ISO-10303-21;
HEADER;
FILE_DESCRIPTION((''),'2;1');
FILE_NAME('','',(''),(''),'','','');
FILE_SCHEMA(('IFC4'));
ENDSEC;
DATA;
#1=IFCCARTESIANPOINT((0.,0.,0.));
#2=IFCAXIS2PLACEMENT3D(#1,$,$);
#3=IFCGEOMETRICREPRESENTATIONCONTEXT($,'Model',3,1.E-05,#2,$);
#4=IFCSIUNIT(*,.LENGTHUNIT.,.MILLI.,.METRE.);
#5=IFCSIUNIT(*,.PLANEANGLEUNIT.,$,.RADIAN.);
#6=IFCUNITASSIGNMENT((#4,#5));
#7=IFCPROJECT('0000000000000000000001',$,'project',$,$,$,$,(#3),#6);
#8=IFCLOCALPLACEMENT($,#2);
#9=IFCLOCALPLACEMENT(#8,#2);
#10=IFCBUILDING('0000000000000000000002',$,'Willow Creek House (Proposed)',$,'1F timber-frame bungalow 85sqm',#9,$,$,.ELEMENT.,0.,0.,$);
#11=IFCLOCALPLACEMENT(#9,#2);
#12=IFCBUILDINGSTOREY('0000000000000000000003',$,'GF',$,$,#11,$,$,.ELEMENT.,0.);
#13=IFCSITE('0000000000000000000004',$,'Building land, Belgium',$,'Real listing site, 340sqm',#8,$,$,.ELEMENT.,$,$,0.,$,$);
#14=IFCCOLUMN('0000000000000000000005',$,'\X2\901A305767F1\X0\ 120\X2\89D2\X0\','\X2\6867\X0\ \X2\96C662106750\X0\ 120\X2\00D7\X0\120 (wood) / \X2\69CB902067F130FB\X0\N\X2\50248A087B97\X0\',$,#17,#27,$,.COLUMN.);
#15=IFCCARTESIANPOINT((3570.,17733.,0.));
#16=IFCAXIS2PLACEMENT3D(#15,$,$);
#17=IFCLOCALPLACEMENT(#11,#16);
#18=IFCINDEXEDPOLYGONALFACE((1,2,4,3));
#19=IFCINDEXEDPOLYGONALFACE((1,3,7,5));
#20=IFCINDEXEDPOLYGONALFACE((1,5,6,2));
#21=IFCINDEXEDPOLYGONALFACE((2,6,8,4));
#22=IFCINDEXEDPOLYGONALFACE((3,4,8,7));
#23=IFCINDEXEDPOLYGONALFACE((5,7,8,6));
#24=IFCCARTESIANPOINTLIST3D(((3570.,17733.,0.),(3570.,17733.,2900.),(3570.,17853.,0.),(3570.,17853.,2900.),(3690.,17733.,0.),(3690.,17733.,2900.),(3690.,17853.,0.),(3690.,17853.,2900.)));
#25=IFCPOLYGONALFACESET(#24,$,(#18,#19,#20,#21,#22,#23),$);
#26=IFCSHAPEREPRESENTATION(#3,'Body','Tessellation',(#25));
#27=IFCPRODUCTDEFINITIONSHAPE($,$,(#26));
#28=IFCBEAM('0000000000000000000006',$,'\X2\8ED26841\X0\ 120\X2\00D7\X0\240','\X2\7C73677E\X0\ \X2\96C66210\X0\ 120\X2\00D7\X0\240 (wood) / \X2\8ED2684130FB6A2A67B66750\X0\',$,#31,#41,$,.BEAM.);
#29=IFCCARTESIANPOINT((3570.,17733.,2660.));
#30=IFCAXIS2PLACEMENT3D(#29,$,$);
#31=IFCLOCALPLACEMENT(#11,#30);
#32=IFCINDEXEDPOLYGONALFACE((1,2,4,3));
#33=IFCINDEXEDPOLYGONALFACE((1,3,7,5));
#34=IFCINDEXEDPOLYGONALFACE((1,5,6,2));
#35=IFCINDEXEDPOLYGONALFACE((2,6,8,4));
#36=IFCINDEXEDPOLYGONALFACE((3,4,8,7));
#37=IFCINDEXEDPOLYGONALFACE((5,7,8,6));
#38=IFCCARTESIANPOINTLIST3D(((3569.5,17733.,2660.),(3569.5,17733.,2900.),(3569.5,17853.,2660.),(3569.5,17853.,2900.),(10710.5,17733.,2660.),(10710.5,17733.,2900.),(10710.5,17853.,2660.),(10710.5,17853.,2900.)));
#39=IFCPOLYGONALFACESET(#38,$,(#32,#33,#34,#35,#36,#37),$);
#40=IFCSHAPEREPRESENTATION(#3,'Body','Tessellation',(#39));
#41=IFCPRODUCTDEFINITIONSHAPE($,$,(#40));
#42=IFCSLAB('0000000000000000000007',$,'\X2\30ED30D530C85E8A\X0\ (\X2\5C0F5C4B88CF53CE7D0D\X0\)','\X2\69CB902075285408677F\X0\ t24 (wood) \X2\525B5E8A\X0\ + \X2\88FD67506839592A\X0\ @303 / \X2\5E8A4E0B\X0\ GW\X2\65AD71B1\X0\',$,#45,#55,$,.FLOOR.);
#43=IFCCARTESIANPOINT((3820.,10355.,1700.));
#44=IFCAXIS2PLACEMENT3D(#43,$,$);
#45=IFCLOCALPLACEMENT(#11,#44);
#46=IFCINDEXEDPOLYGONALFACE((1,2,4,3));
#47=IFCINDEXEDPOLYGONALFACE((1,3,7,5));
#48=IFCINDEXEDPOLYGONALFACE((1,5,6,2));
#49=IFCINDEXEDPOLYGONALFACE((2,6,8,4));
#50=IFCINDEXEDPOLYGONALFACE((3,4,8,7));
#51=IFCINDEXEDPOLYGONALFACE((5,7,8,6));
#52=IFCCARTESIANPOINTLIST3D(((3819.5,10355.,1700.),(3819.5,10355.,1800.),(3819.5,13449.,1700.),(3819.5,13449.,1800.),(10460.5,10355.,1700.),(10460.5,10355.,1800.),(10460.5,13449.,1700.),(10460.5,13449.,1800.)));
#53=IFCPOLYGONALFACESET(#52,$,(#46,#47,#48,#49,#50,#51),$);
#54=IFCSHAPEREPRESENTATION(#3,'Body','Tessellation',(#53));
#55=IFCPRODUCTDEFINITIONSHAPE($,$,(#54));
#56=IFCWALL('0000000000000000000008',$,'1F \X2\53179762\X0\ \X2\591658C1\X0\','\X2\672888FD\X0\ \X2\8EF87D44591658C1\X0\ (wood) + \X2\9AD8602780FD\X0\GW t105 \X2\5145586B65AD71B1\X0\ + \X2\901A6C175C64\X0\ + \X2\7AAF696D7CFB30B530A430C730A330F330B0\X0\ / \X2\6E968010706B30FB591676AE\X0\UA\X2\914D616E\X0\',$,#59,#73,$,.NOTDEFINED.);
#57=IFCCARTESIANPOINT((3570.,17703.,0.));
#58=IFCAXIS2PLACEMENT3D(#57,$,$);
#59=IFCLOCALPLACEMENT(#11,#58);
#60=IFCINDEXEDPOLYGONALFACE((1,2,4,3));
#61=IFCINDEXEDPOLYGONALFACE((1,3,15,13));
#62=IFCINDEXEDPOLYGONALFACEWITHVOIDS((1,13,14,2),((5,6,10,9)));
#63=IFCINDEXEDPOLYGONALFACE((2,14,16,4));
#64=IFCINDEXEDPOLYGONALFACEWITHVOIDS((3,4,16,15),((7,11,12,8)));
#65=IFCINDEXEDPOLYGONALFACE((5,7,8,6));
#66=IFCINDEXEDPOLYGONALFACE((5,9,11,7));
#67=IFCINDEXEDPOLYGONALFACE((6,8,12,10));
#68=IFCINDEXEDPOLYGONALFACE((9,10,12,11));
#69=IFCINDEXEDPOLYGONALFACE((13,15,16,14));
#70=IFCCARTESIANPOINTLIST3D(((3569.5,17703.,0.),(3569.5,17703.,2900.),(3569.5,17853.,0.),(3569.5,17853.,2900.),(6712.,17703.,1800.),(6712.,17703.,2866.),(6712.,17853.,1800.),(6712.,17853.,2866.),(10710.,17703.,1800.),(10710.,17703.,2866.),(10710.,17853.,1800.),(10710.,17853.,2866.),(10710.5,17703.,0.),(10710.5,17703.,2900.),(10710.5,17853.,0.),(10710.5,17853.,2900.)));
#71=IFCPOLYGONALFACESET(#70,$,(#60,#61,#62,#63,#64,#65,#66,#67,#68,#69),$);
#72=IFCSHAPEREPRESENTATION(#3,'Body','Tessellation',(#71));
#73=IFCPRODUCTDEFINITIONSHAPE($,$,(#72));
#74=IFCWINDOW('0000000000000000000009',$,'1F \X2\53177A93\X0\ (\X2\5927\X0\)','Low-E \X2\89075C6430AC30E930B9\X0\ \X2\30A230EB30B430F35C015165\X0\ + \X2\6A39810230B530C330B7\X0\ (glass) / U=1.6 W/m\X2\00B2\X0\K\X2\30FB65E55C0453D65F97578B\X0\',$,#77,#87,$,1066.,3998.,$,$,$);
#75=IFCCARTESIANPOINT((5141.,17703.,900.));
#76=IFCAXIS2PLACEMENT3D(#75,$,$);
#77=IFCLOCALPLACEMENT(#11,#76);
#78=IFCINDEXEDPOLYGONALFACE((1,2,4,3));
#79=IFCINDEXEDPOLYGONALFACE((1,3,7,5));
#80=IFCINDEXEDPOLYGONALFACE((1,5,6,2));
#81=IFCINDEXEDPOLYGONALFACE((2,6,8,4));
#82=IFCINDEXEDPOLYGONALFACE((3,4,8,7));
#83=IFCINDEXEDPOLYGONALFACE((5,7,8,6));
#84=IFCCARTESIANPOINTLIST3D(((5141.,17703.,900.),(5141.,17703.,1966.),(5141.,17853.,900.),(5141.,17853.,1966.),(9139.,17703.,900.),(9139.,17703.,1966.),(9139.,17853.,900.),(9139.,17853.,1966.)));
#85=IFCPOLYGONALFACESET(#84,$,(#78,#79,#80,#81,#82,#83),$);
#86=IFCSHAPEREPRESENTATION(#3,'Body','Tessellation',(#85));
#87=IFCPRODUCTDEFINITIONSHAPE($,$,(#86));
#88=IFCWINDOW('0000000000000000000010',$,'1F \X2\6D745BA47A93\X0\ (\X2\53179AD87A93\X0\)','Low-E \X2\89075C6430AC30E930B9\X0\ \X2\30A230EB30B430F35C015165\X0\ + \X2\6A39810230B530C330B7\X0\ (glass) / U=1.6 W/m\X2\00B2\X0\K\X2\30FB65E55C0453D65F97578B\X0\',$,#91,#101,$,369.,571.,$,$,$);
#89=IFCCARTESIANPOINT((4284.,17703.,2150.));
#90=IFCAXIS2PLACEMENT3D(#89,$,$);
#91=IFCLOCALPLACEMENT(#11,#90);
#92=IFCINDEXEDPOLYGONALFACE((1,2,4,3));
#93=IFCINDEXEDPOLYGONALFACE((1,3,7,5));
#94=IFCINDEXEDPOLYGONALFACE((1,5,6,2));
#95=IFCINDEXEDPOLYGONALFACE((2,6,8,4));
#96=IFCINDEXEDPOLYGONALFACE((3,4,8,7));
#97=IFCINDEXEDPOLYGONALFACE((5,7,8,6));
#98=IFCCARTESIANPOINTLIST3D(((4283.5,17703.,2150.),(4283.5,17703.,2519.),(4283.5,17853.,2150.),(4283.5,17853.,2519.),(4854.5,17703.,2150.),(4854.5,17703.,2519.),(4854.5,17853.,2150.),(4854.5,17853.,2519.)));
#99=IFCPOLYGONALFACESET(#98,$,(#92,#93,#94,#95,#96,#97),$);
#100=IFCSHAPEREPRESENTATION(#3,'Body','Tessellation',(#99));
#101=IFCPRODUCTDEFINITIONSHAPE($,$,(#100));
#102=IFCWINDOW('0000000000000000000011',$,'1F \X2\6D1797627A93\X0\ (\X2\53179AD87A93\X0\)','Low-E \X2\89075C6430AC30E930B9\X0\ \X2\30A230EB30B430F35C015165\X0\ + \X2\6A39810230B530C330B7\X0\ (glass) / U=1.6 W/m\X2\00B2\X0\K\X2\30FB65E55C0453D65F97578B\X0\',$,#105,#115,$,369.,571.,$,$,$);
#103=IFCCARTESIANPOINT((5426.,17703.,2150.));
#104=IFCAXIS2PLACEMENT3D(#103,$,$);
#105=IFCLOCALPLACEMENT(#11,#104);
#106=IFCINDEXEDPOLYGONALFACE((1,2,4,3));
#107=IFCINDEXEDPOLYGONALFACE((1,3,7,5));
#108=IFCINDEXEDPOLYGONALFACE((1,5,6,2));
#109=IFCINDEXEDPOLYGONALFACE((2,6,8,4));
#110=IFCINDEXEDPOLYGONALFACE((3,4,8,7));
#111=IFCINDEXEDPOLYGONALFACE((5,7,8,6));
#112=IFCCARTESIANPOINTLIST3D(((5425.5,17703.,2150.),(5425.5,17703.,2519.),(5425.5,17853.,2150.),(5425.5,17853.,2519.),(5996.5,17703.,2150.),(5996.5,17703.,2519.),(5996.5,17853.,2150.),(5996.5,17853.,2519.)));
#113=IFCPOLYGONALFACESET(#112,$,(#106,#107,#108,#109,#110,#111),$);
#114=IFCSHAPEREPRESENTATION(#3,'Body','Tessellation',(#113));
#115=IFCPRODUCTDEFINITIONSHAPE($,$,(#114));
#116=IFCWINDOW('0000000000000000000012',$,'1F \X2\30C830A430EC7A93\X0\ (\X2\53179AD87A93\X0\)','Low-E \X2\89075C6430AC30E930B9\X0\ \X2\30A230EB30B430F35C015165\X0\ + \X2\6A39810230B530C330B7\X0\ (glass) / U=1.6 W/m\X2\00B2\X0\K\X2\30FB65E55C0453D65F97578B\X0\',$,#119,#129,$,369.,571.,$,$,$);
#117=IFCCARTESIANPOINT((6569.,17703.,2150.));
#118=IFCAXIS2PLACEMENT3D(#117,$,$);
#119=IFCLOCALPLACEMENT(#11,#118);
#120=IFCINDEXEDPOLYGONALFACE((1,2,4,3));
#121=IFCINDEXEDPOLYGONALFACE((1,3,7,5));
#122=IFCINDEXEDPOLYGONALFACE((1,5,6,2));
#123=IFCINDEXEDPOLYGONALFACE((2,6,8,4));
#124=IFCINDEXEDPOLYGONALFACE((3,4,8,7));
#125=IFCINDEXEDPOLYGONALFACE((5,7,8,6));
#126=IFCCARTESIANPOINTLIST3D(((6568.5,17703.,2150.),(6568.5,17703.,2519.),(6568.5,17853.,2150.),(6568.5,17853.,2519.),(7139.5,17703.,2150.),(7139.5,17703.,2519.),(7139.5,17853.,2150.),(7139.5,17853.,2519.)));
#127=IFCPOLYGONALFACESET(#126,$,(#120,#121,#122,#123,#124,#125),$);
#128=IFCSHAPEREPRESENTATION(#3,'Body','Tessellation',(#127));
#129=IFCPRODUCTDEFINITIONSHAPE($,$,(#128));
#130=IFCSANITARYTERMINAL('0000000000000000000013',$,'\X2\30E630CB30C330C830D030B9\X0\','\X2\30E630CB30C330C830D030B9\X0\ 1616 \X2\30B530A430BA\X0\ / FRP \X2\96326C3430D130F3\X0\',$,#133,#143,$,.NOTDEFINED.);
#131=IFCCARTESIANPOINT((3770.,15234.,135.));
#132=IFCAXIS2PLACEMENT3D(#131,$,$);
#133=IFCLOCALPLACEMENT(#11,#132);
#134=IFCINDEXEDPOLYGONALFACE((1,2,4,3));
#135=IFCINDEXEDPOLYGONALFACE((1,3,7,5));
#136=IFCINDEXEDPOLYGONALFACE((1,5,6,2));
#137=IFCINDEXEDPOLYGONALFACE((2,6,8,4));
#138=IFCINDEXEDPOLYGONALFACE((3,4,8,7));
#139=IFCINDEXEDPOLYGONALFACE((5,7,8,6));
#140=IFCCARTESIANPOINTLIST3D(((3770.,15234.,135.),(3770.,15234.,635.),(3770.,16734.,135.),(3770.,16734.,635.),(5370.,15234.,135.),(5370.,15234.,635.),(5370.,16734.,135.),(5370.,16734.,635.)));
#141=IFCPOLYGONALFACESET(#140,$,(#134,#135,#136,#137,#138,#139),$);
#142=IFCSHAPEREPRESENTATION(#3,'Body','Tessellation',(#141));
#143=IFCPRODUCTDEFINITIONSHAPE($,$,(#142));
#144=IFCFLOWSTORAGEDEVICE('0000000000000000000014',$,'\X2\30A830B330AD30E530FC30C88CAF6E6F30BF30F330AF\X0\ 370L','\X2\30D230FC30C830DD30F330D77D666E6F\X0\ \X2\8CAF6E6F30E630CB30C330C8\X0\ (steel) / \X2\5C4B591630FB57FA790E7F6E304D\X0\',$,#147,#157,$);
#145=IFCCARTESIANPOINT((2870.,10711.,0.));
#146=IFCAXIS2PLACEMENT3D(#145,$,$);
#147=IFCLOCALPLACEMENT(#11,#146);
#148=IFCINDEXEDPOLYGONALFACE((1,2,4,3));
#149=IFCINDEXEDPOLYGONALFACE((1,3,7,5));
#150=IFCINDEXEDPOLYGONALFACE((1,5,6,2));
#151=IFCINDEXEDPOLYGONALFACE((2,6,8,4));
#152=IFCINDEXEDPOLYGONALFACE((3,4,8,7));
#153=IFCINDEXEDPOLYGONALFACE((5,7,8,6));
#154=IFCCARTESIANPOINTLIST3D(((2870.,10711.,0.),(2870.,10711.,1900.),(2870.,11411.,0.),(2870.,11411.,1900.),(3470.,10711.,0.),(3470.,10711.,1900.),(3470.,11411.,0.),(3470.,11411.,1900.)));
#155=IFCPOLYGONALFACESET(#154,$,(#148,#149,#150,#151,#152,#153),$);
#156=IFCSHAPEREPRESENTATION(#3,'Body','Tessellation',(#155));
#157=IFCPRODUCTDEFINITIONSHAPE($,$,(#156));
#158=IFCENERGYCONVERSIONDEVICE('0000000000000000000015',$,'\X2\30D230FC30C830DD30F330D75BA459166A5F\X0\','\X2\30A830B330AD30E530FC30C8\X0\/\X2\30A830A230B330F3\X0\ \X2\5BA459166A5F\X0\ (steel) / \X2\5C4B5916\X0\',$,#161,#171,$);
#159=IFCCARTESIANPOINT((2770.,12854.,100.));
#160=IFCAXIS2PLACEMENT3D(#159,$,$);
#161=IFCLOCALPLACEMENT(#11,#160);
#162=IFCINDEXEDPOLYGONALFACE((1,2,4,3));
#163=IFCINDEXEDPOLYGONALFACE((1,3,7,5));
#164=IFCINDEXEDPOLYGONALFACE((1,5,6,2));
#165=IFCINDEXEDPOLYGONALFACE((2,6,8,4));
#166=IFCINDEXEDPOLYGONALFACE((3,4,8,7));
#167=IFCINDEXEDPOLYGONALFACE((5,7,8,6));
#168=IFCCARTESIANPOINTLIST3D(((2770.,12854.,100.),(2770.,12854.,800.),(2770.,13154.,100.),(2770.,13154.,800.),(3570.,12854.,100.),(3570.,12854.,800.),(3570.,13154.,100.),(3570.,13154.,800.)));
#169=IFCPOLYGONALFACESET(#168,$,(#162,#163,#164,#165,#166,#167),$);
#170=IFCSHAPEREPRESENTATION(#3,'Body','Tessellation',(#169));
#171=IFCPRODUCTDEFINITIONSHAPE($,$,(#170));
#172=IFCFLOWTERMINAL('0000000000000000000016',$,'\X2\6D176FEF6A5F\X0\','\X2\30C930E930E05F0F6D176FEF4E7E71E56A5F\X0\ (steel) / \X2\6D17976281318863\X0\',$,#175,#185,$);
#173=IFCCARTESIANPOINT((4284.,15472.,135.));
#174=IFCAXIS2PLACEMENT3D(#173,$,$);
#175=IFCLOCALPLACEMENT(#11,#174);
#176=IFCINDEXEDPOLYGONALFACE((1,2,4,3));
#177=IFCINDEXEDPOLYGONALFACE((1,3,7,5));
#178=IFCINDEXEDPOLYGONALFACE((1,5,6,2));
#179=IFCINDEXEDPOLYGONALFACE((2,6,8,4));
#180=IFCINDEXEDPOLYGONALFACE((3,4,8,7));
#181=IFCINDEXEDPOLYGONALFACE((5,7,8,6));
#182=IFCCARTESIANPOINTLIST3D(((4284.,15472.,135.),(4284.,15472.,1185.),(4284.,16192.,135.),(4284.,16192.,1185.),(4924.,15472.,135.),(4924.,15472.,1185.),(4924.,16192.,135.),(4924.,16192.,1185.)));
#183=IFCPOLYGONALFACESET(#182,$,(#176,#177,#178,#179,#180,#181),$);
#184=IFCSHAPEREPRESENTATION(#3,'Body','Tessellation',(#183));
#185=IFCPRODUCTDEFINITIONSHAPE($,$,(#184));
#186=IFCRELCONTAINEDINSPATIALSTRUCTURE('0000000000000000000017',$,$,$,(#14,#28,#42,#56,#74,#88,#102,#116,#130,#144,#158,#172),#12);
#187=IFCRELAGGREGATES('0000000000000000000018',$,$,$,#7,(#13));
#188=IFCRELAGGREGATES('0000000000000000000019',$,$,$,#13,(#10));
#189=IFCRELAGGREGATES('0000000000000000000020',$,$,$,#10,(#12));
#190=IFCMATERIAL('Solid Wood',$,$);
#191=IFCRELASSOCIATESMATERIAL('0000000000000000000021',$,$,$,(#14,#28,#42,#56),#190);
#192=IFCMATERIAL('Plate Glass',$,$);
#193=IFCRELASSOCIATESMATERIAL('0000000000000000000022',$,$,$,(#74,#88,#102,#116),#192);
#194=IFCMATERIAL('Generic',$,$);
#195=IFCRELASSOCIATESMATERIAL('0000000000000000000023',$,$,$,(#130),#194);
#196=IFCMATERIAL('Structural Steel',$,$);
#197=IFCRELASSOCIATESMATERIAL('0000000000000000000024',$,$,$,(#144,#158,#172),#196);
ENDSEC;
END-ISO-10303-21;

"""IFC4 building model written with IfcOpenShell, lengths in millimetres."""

from ifc_helpers import new_model, si_unit, frame, frame_2d, origin, place, context, project, spatial, rectangle, extrude, material, element, fill, save


model = new_model("IFC4")

# Units and contexts
model_context = context("Model", 3, precision=1e-05, world=origin())
ifc_project = project(units=[si_unit("LENGTHUNIT", "METRE", prefix="MILLI"), si_unit("PLANEANGLEUNIT", "RADIAN")], contexts=[model_context])

# Site, building, storey
site_placement = place(None, origin())
site = spatial("IfcSite", under=ifc_project, at=site_placement, Name="Building land, Belgium", ObjectType="Real listing site, 340sqm", CompositionType="ELEMENT", RefElevation=0.0)
building_placement = place(site_placement, origin())
building = spatial("IfcBuilding", under=site, at=building_placement, Name="Willow Creek House (Proposed)", ObjectType="1F timber-frame bungalow 85sqm", CompositionType="ELEMENT", ElevationOfRefHeight=0.0, ElevationOfTerrain=0.0)
storey_placement = place(building_placement, origin())
storey = spatial("IfcBuildingStorey", under=building, at=storey_placement, Name="GF", CompositionType="ELEMENT", Elevation=0.0)

# Column
ifc_material_1 = material(Name="Solid Wood")
column_1_placement = place(storey_placement, frame((3570.0, 17733.0, 0.0)))
element("IfcColumn", 1, at=column_1_placement, inside=storey, material=ifc_material_1, Name="通し柱 120角", Description="桧 集成材 120×120 (wood) / 構造柱・N値計算", PredefinedType="COLUMN", context=model_context, shape_type="SweptSolid", body=[
    extrude(rectangle(XDim=120.0, YDim=120.0, at=frame_2d((60.0, 60.0))), frame((3570.0, 17733.0, 0.0)), (0.0, 0.0, 1.0), 2900.0),
])

# Beam
beam_1_placement = place(storey_placement, frame((3570.0, 17733.0, 2660.0)))
element("IfcBeam", 2, at=beam_1_placement, inside=storey, material=ifc_material_1, Name="軒桁 120×240", Description="米松 集成 120×240 (wood) / 軒桁・横架材", PredefinedType="BEAM", context=model_context, shape_type="SweptSolid", body=[
    extrude(rectangle(XDim=7141.0, YDim=120.0, at=frame_2d((3570.0, 60.0))), frame((3570.0, 17733.0, 2660.0)), (0.0, 0.0, 1.0), 240.0),
])

# Slab
slab_placement = place(storey_placement, frame((3820.0, 10355.0, 1700.0)))
element("IfcSlab", 3, at=slab_placement, inside=storey, material=ifc_material_1, Name="ロフト床 (小屋裏収納)", Description="構造用合板 t24 (wood) 剛床 + 製材根太 @303 / 床下 GW断熱", PredefinedType="FLOOR", context=model_context, shape_type="SweptSolid", body=[
    extrude(rectangle(XDim=6641.0, YDim=3094.0, at=frame_2d((3320.0, 1547.0))), frame((3820.0, 10355.0, 1700.0)), (0.0, 0.0, 1.0), 100.0),
])

# Wall, openings, windows
wall_1_placement = place(storey_placement, frame((3570.0, 17703.0, 0.0)))
wall_1 = element("IfcWall", 4, at=wall_1_placement, inside=storey, material=ifc_material_1, Name="1F 北面 外壁", Description="木製 軸組外壁 (wood) + 高性能GW t105 充填断熱 + 通気層 + 窯業系サイディング / 準耐火・外皮UA配慮", PredefinedType="NOTDEFINED", context=model_context, shape_type="SweptSolid", body=[
    extrude(rectangle(XDim=7141.0, YDim=150.0, at=frame_2d((3570.0, 75.0))), frame((3570.0, 17703.0, 0.0)), (0.0, 0.0, 1.0), 2900.0),
])
opening_1_placement = place(storey_placement, frame((5141.0, 17703.0, 900.0)))
opening_1 = element("IfcOpeningElement", 5, at=opening_1_placement, cuts=wall_1, PredefinedType="NOTDEFINED", context=model_context, shape_type="SweptSolid", body=[
    extrude(rectangle(XDim=3998.0, YDim=150.0, at=frame_2d((1999.0, 75.0))), frame((5141.0, 17703.0, 900.0)), (0.0, 0.0, 1.0), 1066.0),
])
opening_2_placement = place(storey_placement, frame((4284.0, 17703.0, 2150.0)))
opening_2 = element("IfcOpeningElement", 6, at=opening_2_placement, cuts=wall_1, PredefinedType="NOTDEFINED", context=model_context, shape_type="SweptSolid", body=[
    extrude(rectangle(XDim=571.0, YDim=150.0, at=frame_2d((285.0, 75.0))), frame((4284.0, 17703.0, 2150.0)), (0.0, 0.0, 1.0), 369.0),
])
opening_3_placement = place(storey_placement, frame((5426.0, 17703.0, 2150.0)))
opening_3 = element("IfcOpeningElement", 7, at=opening_3_placement, cuts=wall_1, PredefinedType="NOTDEFINED", context=model_context, shape_type="SweptSolid", body=[
    extrude(rectangle(XDim=571.0, YDim=150.0, at=frame_2d((285.0, 75.0))), frame((5426.0, 17703.0, 2150.0)), (0.0, 0.0, 1.0), 369.0),
])
opening_4_placement = place(storey_placement, frame((6569.0, 17703.0, 2150.0)))
opening_4 = element("IfcOpeningElement", 8, at=opening_4_placement, cuts=wall_1, PredefinedType="NOTDEFINED", context=model_context, shape_type="SweptSolid", body=[
    extrude(rectangle(XDim=571.0, YDim=150.0, at=frame_2d((285.0, 75.0))), frame((6569.0, 17703.0, 2150.0)), (0.0, 0.0, 1.0), 369.0),
])
ifc_material_2 = material(Name="Plate Glass")
window_1_placement = place(storey_placement, frame((5141.0, 17703.0, 900.0)))
window_1 = element("IfcWindow", 9, at=window_1_placement, inside=storey, material=ifc_material_2, Name="1F 北窓 (大)", Description="Low-E 複層ガラス アルゴン封入 + 樹脂サッシ (glass) / U=1.6 W/m²K・日射取得型", OverallHeight=1066.0, OverallWidth=3998.0, context=model_context, shape_type="SweptSolid", body=[
    extrude(rectangle(XDim=3998.0, YDim=150.0, at=frame_2d((1999.0, 75.0))), frame((5141.0, 17703.0, 900.0)), (0.0, 0.0, 1.0), 1066.0),
])
fill(opening_1, window_1)
window_2_placement = place(storey_placement, frame((4284.0, 17703.0, 2150.0)))
window_2 = element("IfcWindow", 10, at=window_2_placement, inside=storey, material=ifc_material_2, Name="1F 浴室窓 (北高窓)", Description="Low-E 複層ガラス アルゴン封入 + 樹脂サッシ (glass) / U=1.6 W/m²K・日射取得型", OverallHeight=369.0, OverallWidth=571.0, context=model_context, shape_type="SweptSolid", body=[
    extrude(rectangle(XDim=571.0, YDim=150.0, at=frame_2d((285.0, 75.0))), frame((4284.0, 17703.0, 2150.0)), (0.0, 0.0, 1.0), 369.0),
])
fill(opening_2, window_2)
window_3_placement = place(storey_placement, frame((5426.0, 17703.0, 2150.0)))
window_3 = element("IfcWindow", 11, at=window_3_placement, inside=storey, material=ifc_material_2, Name="1F 洗面窓 (北高窓)", Description="Low-E 複層ガラス アルゴン封入 + 樹脂サッシ (glass) / U=1.6 W/m²K・日射取得型", OverallHeight=369.0, OverallWidth=571.0, context=model_context, shape_type="SweptSolid", body=[
    extrude(rectangle(XDim=571.0, YDim=150.0, at=frame_2d((285.0, 75.0))), frame((5426.0, 17703.0, 2150.0)), (0.0, 0.0, 1.0), 369.0),
])
fill(opening_3, window_3)
window_4_placement = place(storey_placement, frame((6569.0, 17703.0, 2150.0)))
window_4 = element("IfcWindow", 12, at=window_4_placement, inside=storey, material=ifc_material_2, Name="1F トイレ窓 (北高窓)", Description="Low-E 複層ガラス アルゴン封入 + 樹脂サッシ (glass) / U=1.6 W/m²K・日射取得型", OverallHeight=369.0, OverallWidth=571.0, context=model_context, shape_type="SweptSolid", body=[
    extrude(rectangle(XDim=571.0, YDim=150.0, at=frame_2d((285.0, 75.0))), frame((6569.0, 17703.0, 2150.0)), (0.0, 0.0, 1.0), 369.0),
])
fill(opening_4, window_4)

# Sanitary terminal
ifc_material_3 = material(Name="Generic")
sanitary_terminal_placement = place(storey_placement, frame((3770.0, 15234.0, 135.0)))
element("IfcSanitaryTerminal", 13, at=sanitary_terminal_placement, inside=storey, material=ifc_material_3, Name="ユニットバス", Description="ユニットバス 1616 サイズ / FRP 防水パン", PredefinedType="NOTDEFINED", context=model_context, shape_type="SweptSolid", body=[
    extrude(rectangle(XDim=1600.0, YDim=1500.0, at=frame_2d((800.0, 750.0))), frame((3770.0, 15234.0, 135.0)), (0.0, 0.0, 1.0), 500.0),
])

# Flow storage device
ifc_material_4 = material(Name="Structural Steel")
flow_storage_device_placement = place(storey_placement, frame((2870.0, 10711.0, 0.0)))
element("IfcFlowStorageDevice", 14, at=flow_storage_device_placement, inside=storey, material=ifc_material_4, Name="エコキュート貯湯タンク 370L", Description="ヒートポンプ給湯 貯湯ユニット (steel) / 屋外・基礎置き", context=model_context, shape_type="SweptSolid", body=[
    extrude(rectangle(XDim=600.0, YDim=700.0, at=frame_2d((300.0, 350.0))), frame((2870.0, 10711.0, 0.0)), (0.0, 0.0, 1.0), 1900.0),
])

# Energy conversion device
energy_conversion_device_placement = place(storey_placement, frame((2770.0, 12854.0, 100.0)))
element("IfcEnergyConversionDevice", 15, at=energy_conversion_device_placement, inside=storey, material=ifc_material_4, Name="ヒートポンプ室外機", Description="エコキュート/エアコン 室外機 (steel) / 屋外", context=model_context, shape_type="SweptSolid", body=[
    extrude(rectangle(XDim=800.0, YDim=300.0, at=frame_2d((400.0, 150.0))), frame((2770.0, 12854.0, 100.0)), (0.0, 0.0, 1.0), 700.0),
])

# Flow terminal
flow_terminal_placement = place(storey_placement, frame((4284.0, 15472.0, 135.0)))
element("IfcFlowTerminal", 16, at=flow_terminal_placement, inside=storey, material=ifc_material_4, Name="洗濯機", Description="ドラム式洗濯乾燥機 (steel) / 洗面脱衣", context=model_context, shape_type="SweptSolid", body=[
    extrude(rectangle(XDim=640.0, YDim=720.0, at=frame_2d((320.0, 360.0))), frame((4284.0, 15472.0, 135.0)), (0.0, 0.0, 1.0), 1050.0),
])

save(model, "model.ifc")
